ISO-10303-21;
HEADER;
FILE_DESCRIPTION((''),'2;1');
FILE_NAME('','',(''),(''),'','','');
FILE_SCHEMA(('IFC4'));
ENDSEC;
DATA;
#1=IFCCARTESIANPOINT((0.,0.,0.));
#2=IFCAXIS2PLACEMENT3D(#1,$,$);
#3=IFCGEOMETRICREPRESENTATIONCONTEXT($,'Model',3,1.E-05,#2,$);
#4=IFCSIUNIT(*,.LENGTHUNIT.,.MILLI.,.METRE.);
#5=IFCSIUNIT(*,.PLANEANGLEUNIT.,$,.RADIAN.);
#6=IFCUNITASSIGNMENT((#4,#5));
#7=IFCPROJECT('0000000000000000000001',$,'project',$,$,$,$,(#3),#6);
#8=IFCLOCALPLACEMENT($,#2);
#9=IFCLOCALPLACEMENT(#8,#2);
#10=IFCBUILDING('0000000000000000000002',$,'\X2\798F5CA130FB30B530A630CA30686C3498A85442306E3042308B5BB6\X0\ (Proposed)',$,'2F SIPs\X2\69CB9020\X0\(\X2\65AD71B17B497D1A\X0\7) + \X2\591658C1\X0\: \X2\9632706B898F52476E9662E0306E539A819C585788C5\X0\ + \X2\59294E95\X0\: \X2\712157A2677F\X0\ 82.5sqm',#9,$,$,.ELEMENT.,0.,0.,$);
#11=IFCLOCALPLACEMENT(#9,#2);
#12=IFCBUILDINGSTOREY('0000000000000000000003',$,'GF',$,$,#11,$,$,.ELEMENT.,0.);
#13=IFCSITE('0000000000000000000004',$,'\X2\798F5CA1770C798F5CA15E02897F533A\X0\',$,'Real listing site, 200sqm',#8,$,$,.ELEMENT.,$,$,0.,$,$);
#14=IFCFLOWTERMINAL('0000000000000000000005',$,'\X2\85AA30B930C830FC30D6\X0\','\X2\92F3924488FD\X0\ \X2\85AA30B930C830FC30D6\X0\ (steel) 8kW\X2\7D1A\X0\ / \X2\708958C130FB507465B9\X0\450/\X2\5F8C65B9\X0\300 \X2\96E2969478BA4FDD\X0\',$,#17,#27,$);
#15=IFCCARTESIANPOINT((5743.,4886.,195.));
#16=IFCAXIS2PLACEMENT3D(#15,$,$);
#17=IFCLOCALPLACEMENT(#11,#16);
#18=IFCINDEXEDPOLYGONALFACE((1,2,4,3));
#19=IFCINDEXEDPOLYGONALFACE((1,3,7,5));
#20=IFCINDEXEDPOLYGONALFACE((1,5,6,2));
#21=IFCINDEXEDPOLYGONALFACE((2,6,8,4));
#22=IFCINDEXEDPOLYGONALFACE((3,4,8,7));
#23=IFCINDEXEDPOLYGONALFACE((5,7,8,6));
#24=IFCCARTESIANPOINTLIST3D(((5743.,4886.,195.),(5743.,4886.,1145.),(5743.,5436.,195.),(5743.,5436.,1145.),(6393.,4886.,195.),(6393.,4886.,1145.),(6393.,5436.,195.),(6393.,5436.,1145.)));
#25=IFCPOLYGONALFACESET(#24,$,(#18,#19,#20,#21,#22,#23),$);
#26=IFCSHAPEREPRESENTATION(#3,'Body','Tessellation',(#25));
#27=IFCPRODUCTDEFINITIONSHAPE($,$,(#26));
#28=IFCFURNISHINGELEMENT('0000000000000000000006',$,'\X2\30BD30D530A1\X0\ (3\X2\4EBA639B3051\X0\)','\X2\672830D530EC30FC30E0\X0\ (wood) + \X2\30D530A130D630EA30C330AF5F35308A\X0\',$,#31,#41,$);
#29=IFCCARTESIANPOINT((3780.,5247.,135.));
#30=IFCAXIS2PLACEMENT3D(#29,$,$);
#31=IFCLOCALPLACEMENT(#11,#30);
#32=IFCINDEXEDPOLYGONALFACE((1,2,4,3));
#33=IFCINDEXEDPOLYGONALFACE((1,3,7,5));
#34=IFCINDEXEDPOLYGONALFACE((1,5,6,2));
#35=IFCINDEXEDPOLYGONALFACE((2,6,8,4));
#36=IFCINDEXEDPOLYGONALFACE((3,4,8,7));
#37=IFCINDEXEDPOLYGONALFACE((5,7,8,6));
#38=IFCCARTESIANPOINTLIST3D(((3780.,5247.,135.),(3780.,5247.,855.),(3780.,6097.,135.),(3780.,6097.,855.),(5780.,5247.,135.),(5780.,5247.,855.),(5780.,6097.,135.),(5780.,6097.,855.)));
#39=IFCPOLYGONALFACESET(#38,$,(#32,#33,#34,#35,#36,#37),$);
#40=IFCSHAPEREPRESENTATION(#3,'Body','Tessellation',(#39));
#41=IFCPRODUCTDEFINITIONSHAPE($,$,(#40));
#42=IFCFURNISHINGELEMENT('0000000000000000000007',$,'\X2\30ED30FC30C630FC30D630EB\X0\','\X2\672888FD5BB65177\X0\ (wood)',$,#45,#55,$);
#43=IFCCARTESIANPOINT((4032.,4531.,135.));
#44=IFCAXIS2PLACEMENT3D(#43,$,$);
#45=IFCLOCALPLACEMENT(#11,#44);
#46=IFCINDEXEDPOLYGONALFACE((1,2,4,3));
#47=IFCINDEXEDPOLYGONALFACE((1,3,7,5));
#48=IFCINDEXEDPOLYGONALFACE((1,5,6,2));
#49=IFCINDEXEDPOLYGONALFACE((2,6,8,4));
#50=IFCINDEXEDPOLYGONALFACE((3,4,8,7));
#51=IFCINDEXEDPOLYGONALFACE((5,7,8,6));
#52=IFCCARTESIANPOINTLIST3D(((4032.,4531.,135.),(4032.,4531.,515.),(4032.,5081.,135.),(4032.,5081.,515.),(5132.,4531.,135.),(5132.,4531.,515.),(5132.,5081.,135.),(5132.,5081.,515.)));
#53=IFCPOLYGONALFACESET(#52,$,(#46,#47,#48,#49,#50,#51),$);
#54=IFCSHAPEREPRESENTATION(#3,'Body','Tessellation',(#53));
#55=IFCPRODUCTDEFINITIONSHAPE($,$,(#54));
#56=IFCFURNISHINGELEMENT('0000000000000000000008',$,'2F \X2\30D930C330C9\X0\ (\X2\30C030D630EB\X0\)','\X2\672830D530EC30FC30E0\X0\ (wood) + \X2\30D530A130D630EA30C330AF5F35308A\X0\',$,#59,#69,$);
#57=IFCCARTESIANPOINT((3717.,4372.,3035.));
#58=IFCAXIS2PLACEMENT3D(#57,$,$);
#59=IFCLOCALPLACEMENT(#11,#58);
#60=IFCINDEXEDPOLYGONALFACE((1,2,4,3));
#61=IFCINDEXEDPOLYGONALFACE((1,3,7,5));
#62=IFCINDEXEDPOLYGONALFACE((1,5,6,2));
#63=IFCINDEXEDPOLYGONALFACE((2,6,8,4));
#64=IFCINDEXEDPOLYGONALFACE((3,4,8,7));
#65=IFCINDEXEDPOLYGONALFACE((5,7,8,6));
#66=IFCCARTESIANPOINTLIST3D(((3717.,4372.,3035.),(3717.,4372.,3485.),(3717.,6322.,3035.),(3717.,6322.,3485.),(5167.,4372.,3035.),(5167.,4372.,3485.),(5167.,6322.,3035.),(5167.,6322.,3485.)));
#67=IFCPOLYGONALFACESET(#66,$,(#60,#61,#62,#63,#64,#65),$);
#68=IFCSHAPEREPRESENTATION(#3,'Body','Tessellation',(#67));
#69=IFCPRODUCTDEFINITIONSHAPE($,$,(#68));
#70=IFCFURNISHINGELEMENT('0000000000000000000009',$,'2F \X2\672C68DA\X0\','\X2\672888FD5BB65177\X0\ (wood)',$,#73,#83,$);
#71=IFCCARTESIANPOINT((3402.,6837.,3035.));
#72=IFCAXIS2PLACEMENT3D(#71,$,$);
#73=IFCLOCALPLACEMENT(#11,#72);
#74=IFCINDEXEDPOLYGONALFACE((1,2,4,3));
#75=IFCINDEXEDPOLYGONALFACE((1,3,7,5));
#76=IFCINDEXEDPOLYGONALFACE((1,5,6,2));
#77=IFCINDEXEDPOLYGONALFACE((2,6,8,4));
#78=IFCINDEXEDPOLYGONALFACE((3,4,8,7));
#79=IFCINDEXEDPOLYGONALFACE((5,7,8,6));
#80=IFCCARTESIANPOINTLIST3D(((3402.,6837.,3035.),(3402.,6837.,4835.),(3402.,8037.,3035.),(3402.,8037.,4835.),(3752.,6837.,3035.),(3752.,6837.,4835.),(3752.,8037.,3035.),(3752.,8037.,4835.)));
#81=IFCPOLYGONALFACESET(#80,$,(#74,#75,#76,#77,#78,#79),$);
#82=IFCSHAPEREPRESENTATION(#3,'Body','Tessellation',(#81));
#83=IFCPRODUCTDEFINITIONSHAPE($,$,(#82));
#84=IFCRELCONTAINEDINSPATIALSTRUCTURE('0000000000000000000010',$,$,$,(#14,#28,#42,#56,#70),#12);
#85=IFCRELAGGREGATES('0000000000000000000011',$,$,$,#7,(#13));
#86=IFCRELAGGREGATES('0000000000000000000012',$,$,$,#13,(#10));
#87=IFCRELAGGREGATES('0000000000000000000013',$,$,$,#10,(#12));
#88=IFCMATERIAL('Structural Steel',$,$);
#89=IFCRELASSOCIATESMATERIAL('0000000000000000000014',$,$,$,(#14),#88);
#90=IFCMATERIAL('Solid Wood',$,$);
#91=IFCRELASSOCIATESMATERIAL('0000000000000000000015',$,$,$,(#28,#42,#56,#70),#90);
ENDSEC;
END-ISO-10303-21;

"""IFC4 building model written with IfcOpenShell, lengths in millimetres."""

from ifc_helpers import new_model, si_unit, frame, frame_2d, origin, place, context, project, spatial, rectangle, extrude, material, element, save


model = new_model("IFC4")

# Units and contexts
model_context = context("Model", 3, precision=1e-05, world=origin())
ifc_project = project(units=[si_unit("LENGTHUNIT", "METRE", prefix="MILLI"), si_unit("PLANEANGLEUNIT", "RADIAN")], contexts=[model_context])

# Site, building, storey
site_placement = place(None, origin())
site = spatial("IfcSite", under=ifc_project, at=site_placement, Name="福岡県福岡市西区", ObjectType="Real listing site, 200sqm", CompositionType="ELEMENT", RefElevation=0.0)
building_placement = place(site_placement, origin())
building = spatial("IfcBuilding", under=site, at=building_placement, Name="福岡・サウナと水風呂のある家 (Proposed)", ObjectType="2F SIPs構造(断熱等級7) + 外壁: 防火規則準拠の厚膜塗装 + 天井: 無垢板 82.5sqm", CompositionType="ELEMENT", ElevationOfRefHeight=0.0, ElevationOfTerrain=0.0)
storey_placement = place(building_placement, origin())
storey = spatial("IfcBuildingStorey", under=building, at=storey_placement, Name="GF", CompositionType="ELEMENT", Elevation=0.0)

# Shared definitions
ifc_material_1 = material(Name="Solid Wood")

# Shared definitions
ifc_material_2 = material(Name="Structural Steel")

# Flow terminal
flow_terminal_1_placement = place(storey_placement, frame((5743.0, 4886.0, 195.0)))
element("IfcFlowTerminal", 1, at=flow_terminal_1_placement, inside=storey, material=ifc_material_2, Name="薪ストーブ", Description="鋳鉄製 薪ストーブ (steel) 8kW級 / 炉壁・側方450/後方300 離隔確保", context=model_context, shape_type="SweptSolid", body=[
    extrude(rectangle(XDim=650.0, YDim=550.0, at=frame_2d((325.0, 275.0))), frame((5743.0, 4886.0, 195.0)), (0.0, 0.0, 1.0), 950.0),
])

# Furnishing elements
furnishing_1_placement = place(storey_placement, frame((3780.0, 5247.0, 135.0)))
element("IfcFurnishingElement", 2, at=furnishing_1_placement, inside=storey, material=ifc_material_1, Name="ソファ (3人掛け)", Description="木フレーム (wood) + ファブリック張り", context=model_context, shape_type="SweptSolid", body=[
    extrude(rectangle(XDim=2000.0, YDim=850.0, at=frame_2d((1000.0, 425.0))), frame((3780.0, 5247.0, 135.0)), (0.0, 0.0, 1.0), 720.0),
])
furnishing_2_placement = place(storey_placement, frame((4032.0, 4531.0, 135.0)))
element("IfcFurnishingElement", 3, at=furnishing_2_placement, inside=storey, material=ifc_material_1, Name="ローテーブル", Description="木製家具 (wood)", context=model_context, shape_type="SweptSolid", body=[
    extrude(rectangle(XDim=1100.0, YDim=550.0, at=frame_2d((550.0, 275.0))), frame((4032.0, 4531.0, 135.0)), (0.0, 0.0, 1.0), 380.0),
])
furnishing_3_placement = place(storey_placement, frame((3717.0, 4372.0, 3035.0)))
element("IfcFurnishingElement", 4, at=furnishing_3_placement, inside=storey, material=ifc_material_1, Name="2F ベッド (ダブル)", Description="木フレーム (wood) + ファブリック張り", context=model_context, shape_type="SweptSolid", body=[
    extrude(rectangle(XDim=1450.0, YDim=1950.0, at=frame_2d((725.0, 975.0))), frame((3717.0, 4372.0, 3035.0)), (0.0, 0.0, 1.0), 450.0),
])
furnishing_4_placement = place(storey_placement, frame((3402.0, 6837.0, 3035.0)))
element("IfcFurnishingElement", 5, at=furnishing_4_placement, inside=storey, material=ifc_material_1, Name="2F 本棚", Description="木製家具 (wood)", context=model_context, shape_type="SweptSolid", body=[
    extrude(rectangle(XDim=350.0, YDim=1200.0, at=frame_2d((175.0, 600.0))), frame((3402.0, 6837.0, 3035.0)), (0.0, 0.0, 1.0), 1800.0),
])

save(model, "model.ifc")
